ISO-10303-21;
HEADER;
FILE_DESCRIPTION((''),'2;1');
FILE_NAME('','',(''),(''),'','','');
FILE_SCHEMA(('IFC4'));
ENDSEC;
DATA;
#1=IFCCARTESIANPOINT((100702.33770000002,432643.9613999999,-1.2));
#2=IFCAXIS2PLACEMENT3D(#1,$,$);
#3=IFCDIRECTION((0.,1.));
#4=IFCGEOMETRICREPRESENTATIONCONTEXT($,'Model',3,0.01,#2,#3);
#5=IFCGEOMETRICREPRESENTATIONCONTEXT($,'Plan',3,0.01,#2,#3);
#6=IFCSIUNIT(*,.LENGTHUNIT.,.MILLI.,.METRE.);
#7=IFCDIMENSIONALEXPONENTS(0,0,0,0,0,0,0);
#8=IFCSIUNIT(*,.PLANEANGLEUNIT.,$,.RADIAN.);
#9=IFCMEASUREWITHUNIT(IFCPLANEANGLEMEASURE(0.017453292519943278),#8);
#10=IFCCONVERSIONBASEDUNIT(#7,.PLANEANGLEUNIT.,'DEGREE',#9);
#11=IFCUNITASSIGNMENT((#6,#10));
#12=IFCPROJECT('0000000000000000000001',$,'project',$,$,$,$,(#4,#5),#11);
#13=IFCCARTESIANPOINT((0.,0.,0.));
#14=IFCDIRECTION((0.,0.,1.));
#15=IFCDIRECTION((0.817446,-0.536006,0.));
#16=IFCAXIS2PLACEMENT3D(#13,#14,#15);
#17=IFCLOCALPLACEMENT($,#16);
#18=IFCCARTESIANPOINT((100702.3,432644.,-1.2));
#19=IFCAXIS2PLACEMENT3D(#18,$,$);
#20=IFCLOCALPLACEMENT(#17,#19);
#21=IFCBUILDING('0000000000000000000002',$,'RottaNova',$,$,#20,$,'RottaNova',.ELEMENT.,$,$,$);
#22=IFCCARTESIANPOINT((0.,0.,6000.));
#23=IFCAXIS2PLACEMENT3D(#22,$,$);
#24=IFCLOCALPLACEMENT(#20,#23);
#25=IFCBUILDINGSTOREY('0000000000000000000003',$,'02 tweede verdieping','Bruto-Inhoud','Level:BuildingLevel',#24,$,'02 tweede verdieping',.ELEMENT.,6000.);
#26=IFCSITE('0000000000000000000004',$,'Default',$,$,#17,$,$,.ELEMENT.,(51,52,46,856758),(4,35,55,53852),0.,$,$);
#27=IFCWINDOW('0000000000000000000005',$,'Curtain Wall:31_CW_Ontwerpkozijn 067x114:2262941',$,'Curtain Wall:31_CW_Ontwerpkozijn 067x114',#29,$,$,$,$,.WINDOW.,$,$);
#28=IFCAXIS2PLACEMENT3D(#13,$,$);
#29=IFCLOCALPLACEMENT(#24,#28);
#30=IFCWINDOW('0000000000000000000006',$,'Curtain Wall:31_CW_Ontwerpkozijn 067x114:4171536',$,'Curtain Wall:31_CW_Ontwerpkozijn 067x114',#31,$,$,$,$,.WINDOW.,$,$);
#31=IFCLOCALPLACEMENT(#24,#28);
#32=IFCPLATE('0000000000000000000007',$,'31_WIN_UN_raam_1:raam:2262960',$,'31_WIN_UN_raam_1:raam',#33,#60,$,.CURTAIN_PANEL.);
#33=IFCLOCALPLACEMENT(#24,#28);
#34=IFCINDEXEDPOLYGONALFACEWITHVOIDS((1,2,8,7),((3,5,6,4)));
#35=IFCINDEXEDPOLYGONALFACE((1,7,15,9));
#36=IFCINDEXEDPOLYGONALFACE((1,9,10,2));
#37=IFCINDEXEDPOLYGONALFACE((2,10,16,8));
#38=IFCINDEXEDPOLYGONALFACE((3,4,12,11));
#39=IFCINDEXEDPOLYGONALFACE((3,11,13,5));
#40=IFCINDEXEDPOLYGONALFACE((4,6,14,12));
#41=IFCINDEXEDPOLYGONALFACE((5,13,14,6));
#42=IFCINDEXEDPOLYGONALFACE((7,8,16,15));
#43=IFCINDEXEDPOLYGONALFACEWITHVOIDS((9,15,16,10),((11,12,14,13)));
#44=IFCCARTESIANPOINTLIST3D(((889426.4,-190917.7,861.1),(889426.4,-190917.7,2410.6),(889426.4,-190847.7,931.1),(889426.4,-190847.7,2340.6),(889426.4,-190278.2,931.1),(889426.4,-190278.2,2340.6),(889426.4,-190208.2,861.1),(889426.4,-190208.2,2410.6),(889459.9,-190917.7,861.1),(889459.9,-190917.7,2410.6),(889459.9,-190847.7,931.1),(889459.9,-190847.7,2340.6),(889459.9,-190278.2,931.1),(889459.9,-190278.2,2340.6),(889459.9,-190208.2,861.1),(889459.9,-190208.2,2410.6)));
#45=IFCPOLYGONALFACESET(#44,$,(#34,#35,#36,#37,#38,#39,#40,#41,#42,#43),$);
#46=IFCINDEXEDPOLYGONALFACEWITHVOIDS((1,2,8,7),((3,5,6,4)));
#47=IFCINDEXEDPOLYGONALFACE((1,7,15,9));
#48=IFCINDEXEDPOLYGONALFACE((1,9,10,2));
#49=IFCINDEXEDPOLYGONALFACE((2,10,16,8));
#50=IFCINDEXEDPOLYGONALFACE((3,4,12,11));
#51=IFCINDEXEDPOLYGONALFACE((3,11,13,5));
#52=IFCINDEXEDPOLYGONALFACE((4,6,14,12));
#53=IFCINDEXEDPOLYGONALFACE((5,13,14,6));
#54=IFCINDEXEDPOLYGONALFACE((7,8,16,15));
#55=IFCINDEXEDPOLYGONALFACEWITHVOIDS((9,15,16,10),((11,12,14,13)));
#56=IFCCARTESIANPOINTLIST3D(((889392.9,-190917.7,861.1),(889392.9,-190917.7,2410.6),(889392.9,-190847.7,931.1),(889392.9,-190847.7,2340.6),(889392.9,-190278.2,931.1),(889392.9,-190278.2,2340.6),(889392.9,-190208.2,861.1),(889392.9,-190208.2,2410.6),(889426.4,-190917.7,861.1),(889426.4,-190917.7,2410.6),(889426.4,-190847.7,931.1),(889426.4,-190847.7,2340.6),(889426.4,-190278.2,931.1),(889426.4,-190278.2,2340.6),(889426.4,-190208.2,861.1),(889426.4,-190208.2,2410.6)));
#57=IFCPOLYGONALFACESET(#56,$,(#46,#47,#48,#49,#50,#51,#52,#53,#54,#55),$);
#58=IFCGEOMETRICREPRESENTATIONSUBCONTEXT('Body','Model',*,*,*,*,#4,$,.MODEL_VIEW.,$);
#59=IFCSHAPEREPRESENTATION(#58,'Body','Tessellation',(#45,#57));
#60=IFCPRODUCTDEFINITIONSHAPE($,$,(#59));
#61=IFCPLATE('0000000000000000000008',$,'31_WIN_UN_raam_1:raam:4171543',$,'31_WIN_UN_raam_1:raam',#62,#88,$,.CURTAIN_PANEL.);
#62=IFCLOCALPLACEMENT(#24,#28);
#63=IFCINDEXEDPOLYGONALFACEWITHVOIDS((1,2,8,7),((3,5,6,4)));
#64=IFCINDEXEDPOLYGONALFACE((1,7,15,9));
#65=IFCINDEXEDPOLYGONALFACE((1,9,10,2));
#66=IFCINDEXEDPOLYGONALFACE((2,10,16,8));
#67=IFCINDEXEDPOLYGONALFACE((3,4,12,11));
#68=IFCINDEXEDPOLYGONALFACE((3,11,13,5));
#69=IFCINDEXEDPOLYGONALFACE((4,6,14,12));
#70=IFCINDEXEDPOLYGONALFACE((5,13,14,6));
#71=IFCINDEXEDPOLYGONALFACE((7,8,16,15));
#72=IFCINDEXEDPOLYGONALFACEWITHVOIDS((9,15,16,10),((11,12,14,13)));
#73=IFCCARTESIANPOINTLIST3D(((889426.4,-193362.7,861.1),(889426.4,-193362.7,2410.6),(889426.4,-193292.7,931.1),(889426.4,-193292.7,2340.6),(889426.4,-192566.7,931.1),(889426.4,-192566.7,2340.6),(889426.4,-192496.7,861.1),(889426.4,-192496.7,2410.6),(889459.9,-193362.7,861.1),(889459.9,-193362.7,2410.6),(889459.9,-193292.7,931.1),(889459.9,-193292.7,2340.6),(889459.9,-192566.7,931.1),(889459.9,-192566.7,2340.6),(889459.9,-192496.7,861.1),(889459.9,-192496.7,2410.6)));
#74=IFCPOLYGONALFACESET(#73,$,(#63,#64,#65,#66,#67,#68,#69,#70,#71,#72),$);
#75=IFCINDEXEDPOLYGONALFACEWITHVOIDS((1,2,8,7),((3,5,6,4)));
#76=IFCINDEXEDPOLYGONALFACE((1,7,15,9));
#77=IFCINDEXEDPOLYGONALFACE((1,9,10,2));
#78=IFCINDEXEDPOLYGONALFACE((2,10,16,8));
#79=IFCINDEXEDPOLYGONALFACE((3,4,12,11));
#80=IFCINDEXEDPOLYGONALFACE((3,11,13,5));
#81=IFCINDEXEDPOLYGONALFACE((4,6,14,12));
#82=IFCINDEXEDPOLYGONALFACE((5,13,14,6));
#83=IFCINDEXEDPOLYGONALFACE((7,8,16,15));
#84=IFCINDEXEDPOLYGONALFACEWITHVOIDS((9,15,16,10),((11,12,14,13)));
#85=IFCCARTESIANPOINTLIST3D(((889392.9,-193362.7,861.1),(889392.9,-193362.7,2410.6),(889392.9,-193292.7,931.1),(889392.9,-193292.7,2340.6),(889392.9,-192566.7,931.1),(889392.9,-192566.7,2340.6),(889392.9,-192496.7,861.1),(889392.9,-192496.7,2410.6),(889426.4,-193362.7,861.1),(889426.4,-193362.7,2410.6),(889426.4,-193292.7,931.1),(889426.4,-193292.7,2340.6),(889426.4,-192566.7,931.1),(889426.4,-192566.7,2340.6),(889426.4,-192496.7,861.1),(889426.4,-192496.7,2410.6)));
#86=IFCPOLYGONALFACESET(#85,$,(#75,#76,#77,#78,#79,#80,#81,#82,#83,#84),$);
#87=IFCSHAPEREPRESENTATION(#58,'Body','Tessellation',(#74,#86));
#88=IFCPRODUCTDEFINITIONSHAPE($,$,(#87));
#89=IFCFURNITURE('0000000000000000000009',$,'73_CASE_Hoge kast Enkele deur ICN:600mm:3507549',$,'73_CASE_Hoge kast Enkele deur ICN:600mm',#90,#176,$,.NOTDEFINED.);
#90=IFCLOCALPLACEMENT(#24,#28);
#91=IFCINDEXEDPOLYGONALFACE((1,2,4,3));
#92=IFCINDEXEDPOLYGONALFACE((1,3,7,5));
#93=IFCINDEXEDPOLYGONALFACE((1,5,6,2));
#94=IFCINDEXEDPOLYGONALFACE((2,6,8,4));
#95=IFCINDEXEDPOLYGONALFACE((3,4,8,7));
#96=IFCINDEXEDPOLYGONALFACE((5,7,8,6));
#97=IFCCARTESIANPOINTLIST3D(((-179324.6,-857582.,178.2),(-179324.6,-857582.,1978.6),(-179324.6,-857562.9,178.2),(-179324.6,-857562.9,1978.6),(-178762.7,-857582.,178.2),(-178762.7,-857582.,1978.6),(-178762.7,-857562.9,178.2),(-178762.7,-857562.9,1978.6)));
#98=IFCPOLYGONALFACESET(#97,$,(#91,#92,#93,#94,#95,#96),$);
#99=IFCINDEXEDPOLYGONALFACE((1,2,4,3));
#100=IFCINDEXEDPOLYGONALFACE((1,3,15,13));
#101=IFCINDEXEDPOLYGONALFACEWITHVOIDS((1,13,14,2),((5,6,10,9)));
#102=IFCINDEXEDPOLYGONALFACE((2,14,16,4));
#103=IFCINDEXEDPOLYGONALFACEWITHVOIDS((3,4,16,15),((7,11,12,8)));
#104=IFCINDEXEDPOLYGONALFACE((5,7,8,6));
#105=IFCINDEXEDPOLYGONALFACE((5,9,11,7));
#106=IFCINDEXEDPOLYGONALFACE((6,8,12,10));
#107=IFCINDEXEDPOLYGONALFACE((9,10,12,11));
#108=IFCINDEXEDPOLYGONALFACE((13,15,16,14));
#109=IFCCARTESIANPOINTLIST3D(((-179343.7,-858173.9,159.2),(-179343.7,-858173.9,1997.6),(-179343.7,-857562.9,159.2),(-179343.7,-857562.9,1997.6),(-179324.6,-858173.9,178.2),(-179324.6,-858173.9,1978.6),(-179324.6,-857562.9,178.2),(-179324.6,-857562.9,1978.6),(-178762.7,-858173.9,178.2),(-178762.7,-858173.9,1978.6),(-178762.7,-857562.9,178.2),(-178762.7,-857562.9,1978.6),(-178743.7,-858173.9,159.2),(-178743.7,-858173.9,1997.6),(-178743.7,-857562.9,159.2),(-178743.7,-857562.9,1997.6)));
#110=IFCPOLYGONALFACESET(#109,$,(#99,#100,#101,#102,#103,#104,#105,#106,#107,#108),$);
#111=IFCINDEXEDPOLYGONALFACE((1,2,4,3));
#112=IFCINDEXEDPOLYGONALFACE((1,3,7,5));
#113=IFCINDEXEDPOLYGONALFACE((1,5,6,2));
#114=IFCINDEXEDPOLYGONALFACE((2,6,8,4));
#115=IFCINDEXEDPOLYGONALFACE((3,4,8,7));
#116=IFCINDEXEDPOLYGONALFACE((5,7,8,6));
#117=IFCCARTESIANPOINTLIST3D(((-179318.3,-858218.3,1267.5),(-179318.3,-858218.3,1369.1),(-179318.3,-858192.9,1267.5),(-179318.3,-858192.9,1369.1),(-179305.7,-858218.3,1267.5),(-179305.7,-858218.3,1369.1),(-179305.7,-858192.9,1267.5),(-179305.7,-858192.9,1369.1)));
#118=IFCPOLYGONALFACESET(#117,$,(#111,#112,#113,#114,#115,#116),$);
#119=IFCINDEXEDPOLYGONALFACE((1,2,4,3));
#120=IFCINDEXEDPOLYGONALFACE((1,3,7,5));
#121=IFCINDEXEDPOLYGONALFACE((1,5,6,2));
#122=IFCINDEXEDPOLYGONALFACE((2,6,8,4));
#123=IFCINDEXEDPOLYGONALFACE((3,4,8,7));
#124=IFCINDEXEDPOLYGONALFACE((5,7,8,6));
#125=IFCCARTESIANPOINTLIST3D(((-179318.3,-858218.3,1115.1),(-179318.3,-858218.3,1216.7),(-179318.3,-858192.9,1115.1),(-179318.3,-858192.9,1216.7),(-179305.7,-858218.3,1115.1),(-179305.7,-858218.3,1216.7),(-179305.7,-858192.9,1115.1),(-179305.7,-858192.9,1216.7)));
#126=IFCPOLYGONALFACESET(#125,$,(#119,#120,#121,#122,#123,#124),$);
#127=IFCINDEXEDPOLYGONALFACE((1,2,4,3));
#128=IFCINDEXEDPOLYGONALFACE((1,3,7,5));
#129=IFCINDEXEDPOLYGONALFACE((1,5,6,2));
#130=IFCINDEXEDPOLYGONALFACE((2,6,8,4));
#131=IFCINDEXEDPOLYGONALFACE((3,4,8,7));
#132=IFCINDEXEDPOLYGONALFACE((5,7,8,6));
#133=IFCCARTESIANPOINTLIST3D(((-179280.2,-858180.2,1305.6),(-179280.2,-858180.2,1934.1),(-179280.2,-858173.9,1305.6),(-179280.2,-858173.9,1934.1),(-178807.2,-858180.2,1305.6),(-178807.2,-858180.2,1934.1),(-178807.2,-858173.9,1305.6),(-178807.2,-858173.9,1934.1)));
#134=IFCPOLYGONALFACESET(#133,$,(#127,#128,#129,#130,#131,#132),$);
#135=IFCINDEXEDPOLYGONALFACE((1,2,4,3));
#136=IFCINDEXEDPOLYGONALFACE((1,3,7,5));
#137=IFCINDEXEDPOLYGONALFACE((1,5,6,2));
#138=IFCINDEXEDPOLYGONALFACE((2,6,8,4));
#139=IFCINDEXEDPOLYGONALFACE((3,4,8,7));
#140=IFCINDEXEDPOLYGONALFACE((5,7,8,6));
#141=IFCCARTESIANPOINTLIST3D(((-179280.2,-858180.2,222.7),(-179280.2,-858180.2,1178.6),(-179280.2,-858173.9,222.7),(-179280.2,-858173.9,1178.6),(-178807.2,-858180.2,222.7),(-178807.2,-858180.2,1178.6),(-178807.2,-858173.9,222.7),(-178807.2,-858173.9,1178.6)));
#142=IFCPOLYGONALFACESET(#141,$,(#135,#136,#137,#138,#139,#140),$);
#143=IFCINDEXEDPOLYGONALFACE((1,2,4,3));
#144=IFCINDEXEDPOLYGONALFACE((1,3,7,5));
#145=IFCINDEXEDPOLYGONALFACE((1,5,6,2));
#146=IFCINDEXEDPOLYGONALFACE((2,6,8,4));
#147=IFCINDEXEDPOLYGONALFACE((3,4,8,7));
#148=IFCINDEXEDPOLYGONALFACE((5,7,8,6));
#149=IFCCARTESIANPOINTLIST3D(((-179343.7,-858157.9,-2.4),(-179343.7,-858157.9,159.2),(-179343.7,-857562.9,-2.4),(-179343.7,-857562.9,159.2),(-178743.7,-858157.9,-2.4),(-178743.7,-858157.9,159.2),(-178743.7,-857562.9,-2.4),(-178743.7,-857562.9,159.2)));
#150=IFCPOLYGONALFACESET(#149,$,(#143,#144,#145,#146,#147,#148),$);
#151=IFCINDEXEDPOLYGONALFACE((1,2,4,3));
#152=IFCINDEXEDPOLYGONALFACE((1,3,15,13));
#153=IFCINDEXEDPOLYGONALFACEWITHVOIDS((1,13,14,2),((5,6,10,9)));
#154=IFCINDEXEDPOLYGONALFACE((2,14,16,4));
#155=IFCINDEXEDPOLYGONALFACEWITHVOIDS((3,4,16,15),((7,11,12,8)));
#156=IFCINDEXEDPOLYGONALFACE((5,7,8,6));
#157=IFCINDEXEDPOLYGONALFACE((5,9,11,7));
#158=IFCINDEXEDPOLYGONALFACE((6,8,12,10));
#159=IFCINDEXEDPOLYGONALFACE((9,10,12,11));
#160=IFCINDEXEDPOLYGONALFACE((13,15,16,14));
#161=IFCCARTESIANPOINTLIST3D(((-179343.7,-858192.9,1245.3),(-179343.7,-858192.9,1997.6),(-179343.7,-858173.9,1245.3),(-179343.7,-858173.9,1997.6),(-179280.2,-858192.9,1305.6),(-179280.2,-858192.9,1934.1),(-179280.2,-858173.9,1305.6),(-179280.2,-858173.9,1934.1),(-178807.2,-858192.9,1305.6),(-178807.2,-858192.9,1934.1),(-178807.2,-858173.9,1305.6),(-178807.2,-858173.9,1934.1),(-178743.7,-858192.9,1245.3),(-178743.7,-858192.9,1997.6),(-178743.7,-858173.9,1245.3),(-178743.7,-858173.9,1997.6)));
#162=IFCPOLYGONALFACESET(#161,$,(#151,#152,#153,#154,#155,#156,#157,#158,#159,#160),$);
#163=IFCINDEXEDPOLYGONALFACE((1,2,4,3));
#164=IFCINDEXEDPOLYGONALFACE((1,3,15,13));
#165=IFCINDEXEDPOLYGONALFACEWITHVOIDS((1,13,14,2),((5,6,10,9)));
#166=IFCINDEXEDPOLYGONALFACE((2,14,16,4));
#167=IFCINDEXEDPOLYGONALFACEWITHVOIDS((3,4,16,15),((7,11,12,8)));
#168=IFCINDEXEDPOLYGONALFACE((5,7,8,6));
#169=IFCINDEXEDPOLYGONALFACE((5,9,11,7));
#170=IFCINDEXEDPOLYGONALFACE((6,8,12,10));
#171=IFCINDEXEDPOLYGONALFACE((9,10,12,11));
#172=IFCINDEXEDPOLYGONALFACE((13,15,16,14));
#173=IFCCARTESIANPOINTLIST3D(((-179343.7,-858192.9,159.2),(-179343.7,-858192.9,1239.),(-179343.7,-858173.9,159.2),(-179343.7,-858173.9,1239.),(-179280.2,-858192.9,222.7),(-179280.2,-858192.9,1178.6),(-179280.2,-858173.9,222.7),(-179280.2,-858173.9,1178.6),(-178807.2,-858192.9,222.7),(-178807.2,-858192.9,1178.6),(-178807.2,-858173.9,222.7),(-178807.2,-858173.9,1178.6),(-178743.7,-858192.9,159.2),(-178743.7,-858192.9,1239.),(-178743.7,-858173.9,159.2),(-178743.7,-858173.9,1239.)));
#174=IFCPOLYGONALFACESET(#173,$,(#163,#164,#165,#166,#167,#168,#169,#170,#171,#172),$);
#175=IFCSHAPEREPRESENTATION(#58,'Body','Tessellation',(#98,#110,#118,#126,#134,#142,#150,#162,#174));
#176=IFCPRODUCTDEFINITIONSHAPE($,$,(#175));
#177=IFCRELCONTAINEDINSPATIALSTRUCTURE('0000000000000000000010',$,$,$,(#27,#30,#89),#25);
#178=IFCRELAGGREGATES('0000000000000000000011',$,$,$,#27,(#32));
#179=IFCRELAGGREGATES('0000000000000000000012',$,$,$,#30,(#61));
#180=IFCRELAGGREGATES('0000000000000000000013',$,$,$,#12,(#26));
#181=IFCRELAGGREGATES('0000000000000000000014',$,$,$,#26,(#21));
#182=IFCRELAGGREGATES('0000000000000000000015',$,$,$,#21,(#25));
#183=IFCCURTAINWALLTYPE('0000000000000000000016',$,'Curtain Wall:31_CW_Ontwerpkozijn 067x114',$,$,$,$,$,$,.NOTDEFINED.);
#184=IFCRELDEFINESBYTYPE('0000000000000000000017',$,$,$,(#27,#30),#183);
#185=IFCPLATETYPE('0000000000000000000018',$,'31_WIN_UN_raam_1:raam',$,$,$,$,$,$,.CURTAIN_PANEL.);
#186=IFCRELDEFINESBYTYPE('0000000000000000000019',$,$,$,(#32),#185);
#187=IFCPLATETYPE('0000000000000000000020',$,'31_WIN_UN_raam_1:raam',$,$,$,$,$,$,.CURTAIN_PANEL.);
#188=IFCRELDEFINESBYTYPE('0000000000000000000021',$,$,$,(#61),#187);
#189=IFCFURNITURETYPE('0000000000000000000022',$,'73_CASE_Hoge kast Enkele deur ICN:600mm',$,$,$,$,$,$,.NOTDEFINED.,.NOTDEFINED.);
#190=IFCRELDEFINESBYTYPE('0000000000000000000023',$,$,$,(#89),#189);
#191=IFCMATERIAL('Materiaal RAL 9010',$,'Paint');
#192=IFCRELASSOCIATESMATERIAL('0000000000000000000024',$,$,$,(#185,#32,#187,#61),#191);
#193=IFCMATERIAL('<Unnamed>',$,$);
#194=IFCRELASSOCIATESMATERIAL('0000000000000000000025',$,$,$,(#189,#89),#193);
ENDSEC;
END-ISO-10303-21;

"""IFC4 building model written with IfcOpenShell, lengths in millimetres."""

from ifc_helpers import new_model, entity, si_unit, converted_unit, direction, frame, place, context, subcontext, project, spatial, indexed_curve, outline, extrude, source, transform, mapped, material, type_object, type_shapes, element, aggregate, save


model = new_model("IFC4")

# Units and contexts
model_context = context("Model", 3, precision=0.01, world=frame((100702.33770000002, 432643.9613999999, -1.2)), true_north=direction((0.0, 1.0)))
plan_context = context("Plan", 3, precision=0.01, world=frame((100702.33770000002, 432643.9613999999, -1.2)), true_north=direction((0.0, 1.0)))
body_context = subcontext(model_context, "Body", "Model", "MODEL_VIEW")
ifc_project = project(units=[si_unit("LENGTHUNIT", "METRE", prefix="MILLI"), converted_unit("PLANEANGLEUNIT", "DEGREE", entity("IfcPlaneAngleMeasure", 0.017453292519943278), si_unit("PLANEANGLEUNIT", "RADIAN"), dimensions=[0, 0, 0, 0, 0, 0, 0])], contexts=[model_context, plan_context])

# Site, building, storey
site_placement = place(None, frame((0.0, 0.0, 0.0), z_axis=(0.0, 0.0, 1.0), x_axis=(0.817446, -0.536006, 0.0)))
site = spatial("IfcSite", under=ifc_project, at=site_placement, Name="Default", CompositionType="ELEMENT", RefLatitude=(51, 52, 46, 856758), RefLongitude=(4, 35, 55, 53852), RefElevation=0.0)
building_placement = place(site_placement, frame((100702.3, 432644.0, -1.2)))
building = spatial("IfcBuilding", under=site, at=building_placement, Name="RottaNova", LongName="RottaNova", CompositionType="ELEMENT")
storey_placement = place(building_placement, frame((0.0, 0.0, 6000.0)))
storey = spatial("IfcBuildingStorey", under=building, at=storey_placement, Name="02 tweede verdieping", Description="Bruto-Inhoud", ObjectType="Level:BuildingLevel", LongName="02 tweede verdieping", CompositionType="ELEMENT", Elevation=6000.0)

# Window
curtain_wall_type = type_object("IfcCurtainWallType", Name="Curtain Wall:31_CW_Ontwerpkozijn 067x114", PredefinedType="NOTDEFINED")
window_1_placement = place(storey_placement, frame((0.0, 0.0, -6000.0)))
window_1 = element("IfcWindow", 1, at=window_1_placement, inside=storey, type_object=curtain_wall_type, Name="Curtain Wall:31_CW_Ontwerpkozijn 067x114:2262941", ObjectType="Curtain Wall:31_CW_Ontwerpkozijn 067x114", PredefinedType="WINDOW")

# Window
window_2_placement = place(storey_placement, frame((0.0, 0.0, -6000.0)))
window_2 = element("IfcWindow", 2, at=window_2_placement, inside=storey, type_object=curtain_wall_type, Name="Curtain Wall:31_CW_Ontwerpkozijn 067x114:4171536", ObjectType="Curtain Wall:31_CW_Ontwerpkozijn 067x114", PredefinedType="WINDOW")

# Plates
ifc_material_1 = material(Name="Materiaal RAL 9010", Category="Paint")
plate_type_1 = type_object("IfcPlateType", Name="31_WIN_UN_raam_1:raam", PredefinedType="CURTAIN_PANEL", material=ifc_material_1)
shared_shape_1 = source(frame((100702.3, 432644.0, -1.2)), body_context, "Body", "SweptSolid", [
    extrude(outline(indexed_curve([(-354.8, -774.7), (354.8, -774.7), (354.8, 774.7), (-354.8, 774.7), (-354.8, -774.7)], self_intersect=False), holes=[indexed_curve([(-284.8, 704.7), (284.8, 704.7), (284.8, -704.8), (-284.8, -704.8), (-284.8, 704.7)], self_intersect=False)]), frame((0.0, 58.5, 774.8), z_axis=(0.0, 1.0, 0.0), x_axis=(1.0, 0.0, 0.0)), (0.0, 0.0, 1.0), 33.5),
    extrude(outline(indexed_curve([(-354.8, -774.7), (354.8, -774.7), (354.8, 774.7), (-354.8, 774.7), (-354.8, -774.7)], self_intersect=False), holes=[indexed_curve([(-284.8, 704.7), (284.8, 704.7), (284.8, -704.8), (-284.8, -704.8), (-284.8, 704.7)], self_intersect=False)]), frame((0.0, 25.0, 774.8), z_axis=(0.0, 1.0, 0.0), x_axis=(1.0, 0.0, 0.0)), (0.0, 0.0, 1.0), 33.5),
])
type_shapes(plate_type_1, [shared_shape_1])
plate_1_placement = place(window_1_placement, frame((24080.0, 10841.7, 6863.5), z_axis=(0.0, 0.0, 1.0), x_axis=(0.0, -1.0, 0.0)))
plate_1 = element("IfcPlate", 3, at=plate_1_placement, type_object=plate_type_1, material=ifc_material_1, Name="31_WIN_UN_raam_1:raam:2262960", ObjectType="31_WIN_UN_raam_1:raam", PredefinedType="CURTAIN_PANEL", context=body_context, shape_type="MappedRepresentation", body=[
    mapped(shared_shape_1, transform((100702.3, 432644.0, -1.2), scale=1.0)),
])
aggregate(window_1, [plate_1])
plate_type_2 = type_object("IfcPlateType", Name="31_WIN_UN_raam_1:raam", PredefinedType="CURTAIN_PANEL", material=ifc_material_1)
shared_shape_2 = source(frame((100702.3, 432644.0, -1.2)), body_context, "Body", "SweptSolid", [
    extrude(outline(indexed_curve([(-433.0, -774.7), (433.0, -774.7), (433.0, 774.7), (-433.0, 774.7), (-433.0, -774.7)], self_intersect=False), holes=[indexed_curve([(-363.0, 704.7), (363.0, 704.7), (363.0, -704.8), (-363.0, -704.8), (-363.0, 704.7)], self_intersect=False)]), frame((0.0, 58.5, 774.8), z_axis=(0.0, 1.0, 0.0), x_axis=(1.0, 0.0, 0.0)), (0.0, 0.0, 1.0), 33.5),
    extrude(outline(indexed_curve([(-433.0, -774.7), (433.0, -774.7), (433.0, 774.7), (-433.0, 774.7), (-433.0, -774.7)], self_intersect=False), holes=[indexed_curve([(-363.0, 704.7), (363.0, 704.7), (363.0, -704.8), (-363.0, -704.8), (-363.0, 704.7)], self_intersect=False)]), frame((0.0, 25.0, 774.8), z_axis=(0.0, 1.0, 0.0), x_axis=(1.0, 0.0, 0.0)), (0.0, 0.0, 1.0), 33.5),
])
type_shapes(plate_type_2, [shared_shape_2])
plate_2_placement = place(window_2_placement, frame((24080.0, 8475.0, 6863.5), z_axis=(0.0, 0.0, 1.0), x_axis=(0.0, -1.0, 0.0)))
plate_2 = element("IfcPlate", 4, at=plate_2_placement, type_object=plate_type_2, material=ifc_material_1, Name="31_WIN_UN_raam_1:raam:4171543", ObjectType="31_WIN_UN_raam_1:raam", PredefinedType="CURTAIN_PANEL", context=body_context, shape_type="MappedRepresentation", body=[
    mapped(shared_shape_2, transform((100702.3, 432644.0, -1.2), scale=1.0)),
])
aggregate(window_2, [plate_2])

# Furniture
ifc_material_2 = material(Name="<Unnamed>")
furniture_type = type_object("IfcFurnitureType", Name="73_CASE_Hoge kast Enkele deur ICN:600mm", AssemblyPlace="NOTDEFINED", PredefinedType="NOTDEFINED", material=ifc_material_2)
shared_shape_3 = source(frame((100702.3, 432644.0, -1.2)), body_context, "Body", "SweptSolid", [
    extrude(outline(indexed_curve([(-280.9, -9.5), (280.9, -9.5), (280.9, 9.5), (-280.9, 9.5), (-280.9, -9.5)], self_intersect=False)), frame((18.7, 9.5, 180.6), z_axis=(0.0, 0.0, 1.0), x_axis=(-1.0, 0.0, 0.0)), (0.0, 0.0, 1.0), 1800.3),
    extrude(outline(indexed_curve([(-300.0, -919.2), (300.0, -919.2), (300.0, 919.2), (-300.0, 919.2), (-300.0, -919.2)], self_intersect=False), holes=[indexed_curve([(-280.9, 900.2), (281.0, 900.2), (281.0, -900.2), (-280.9, -900.2), (-280.9, 900.2)], self_intersect=False)]), frame((18.7, 0.0, 1080.8), z_axis=(0.0, 1.0, 0.0), x_axis=(-1.0, 0.0, 0.0)), (0.0, 0.0, 1.0), 610.9),
    extrude(outline(indexed_curve([(-6.3, -12.7), (6.3, -12.7), (6.3, 12.7), (-6.3, 12.7), (-6.3, -12.7)], self_intersect=False)), frame((287.1, 642.7, 1269.9), z_axis=(0.0, 0.0, 1.0), x_axis=(-1.0, 0.0, 0.0)), (0.0, 0.0, 1.0), 101.6),
    extrude(outline(indexed_curve([(-6.3, -12.7), (6.3, -12.7), (6.3, 12.7), (-6.3, 12.7), (-6.3, -12.7)], self_intersect=False)), frame((287.1, 642.7, 1117.5), z_axis=(0.0, 0.0, 1.0), x_axis=(-1.0, 0.0, 0.0)), (0.0, 0.0, 1.0), 101.6),
    extrude(outline(indexed_curve([(-236.5, -3.2), (236.5, -3.2), (236.5, 3.2), (-236.5, 3.2), (-236.5, -3.2)], self_intersect=False)), frame((18.7, 614.1, 1308.0), z_axis=(0.0, 0.0, 1.0), x_axis=(-1.0, 0.0, 0.0)), (0.0, 0.0, 1.0), 628.5),
    extrude(outline(indexed_curve([(-236.5, -3.2), (236.5, -3.2), (236.5, 3.2), (-236.5, 3.2), (-236.5, -3.2)], self_intersect=False)), frame((18.7, 614.1, 225.1), z_axis=(0.0, 0.0, 1.0), x_axis=(-1.0, 0.0, 0.0)), (0.0, 0.0, 1.0), 956.0),
    extrude(outline(indexed_curve([(-297.5, -300.0), (297.5, -300.0), (297.5, 300.0), (-297.5, 300.0), (-297.5, -300.0)], self_intersect=False)), frame((18.7, 297.5, 0.0), z_axis=(0.0, 0.0, 1.0), x_axis=(0.0, 1.0, 0.0)), (0.0, 0.0, 1.0), 161.6),
    extrude(outline(indexed_curve([(-376.1, -300.0), (376.1, -300.0), (376.1, 300.0), (-376.1, 300.0), (-376.1, -300.0)], self_intersect=False), holes=[indexed_curve([(-312.6, -236.5), (-312.6, 236.5), (315.8, 236.5), (315.8, -236.5), (-312.6, -236.5)], self_intersect=False)]), frame((18.7, 610.9, 1623.9), z_axis=(0.0, 1.0, 0.0), x_axis=(0.0, 0.0, -1.0)), (0.0, 0.0, 1.0), 19.1),
    extrude(outline(indexed_curve([(-300.0, -539.9), (300.0, -539.9), (300.0, 539.9), (-300.0, 539.9), (-300.0, -539.9)], self_intersect=False), holes=[indexed_curve([(-236.5, 479.6), (236.5, 479.6), (236.5, -476.4), (-236.5, -476.4), (-236.5, 479.6)], self_intersect=False)]), frame((18.7, 610.9, 701.5), z_axis=(0.0, 1.0, 0.0), x_axis=(-1.0, 0.0, 0.0)), (0.0, 0.0, 1.0), 19.1),
])
type_shapes(furniture_type, [shared_shape_3])
for number, where, z_axis, x_axis, name in (
    (5, (22379.7, 7725.0, 0.0), (0.0, 0.0, 1.0), (-1.0, 0.0, 0.0), "73_CASE_Hoge kast Enkele deur ICN:600mm:3507549"),
):
    element("IfcFurniture", number, at=place(storey_placement, frame(where, z_axis=z_axis, x_axis=x_axis)), inside=storey, type_object=furniture_type, material=ifc_material_2, Name=name, ObjectType="73_CASE_Hoge kast Enkele deur ICN:600mm", PredefinedType="NOTDEFINED", context=body_context, shape_type="MappedRepresentation", body=[
        mapped(shared_shape_3, transform((100702.3, 432644.0, -1.2), scale=1.0)),
    ])

save(model, "model.ifc")
